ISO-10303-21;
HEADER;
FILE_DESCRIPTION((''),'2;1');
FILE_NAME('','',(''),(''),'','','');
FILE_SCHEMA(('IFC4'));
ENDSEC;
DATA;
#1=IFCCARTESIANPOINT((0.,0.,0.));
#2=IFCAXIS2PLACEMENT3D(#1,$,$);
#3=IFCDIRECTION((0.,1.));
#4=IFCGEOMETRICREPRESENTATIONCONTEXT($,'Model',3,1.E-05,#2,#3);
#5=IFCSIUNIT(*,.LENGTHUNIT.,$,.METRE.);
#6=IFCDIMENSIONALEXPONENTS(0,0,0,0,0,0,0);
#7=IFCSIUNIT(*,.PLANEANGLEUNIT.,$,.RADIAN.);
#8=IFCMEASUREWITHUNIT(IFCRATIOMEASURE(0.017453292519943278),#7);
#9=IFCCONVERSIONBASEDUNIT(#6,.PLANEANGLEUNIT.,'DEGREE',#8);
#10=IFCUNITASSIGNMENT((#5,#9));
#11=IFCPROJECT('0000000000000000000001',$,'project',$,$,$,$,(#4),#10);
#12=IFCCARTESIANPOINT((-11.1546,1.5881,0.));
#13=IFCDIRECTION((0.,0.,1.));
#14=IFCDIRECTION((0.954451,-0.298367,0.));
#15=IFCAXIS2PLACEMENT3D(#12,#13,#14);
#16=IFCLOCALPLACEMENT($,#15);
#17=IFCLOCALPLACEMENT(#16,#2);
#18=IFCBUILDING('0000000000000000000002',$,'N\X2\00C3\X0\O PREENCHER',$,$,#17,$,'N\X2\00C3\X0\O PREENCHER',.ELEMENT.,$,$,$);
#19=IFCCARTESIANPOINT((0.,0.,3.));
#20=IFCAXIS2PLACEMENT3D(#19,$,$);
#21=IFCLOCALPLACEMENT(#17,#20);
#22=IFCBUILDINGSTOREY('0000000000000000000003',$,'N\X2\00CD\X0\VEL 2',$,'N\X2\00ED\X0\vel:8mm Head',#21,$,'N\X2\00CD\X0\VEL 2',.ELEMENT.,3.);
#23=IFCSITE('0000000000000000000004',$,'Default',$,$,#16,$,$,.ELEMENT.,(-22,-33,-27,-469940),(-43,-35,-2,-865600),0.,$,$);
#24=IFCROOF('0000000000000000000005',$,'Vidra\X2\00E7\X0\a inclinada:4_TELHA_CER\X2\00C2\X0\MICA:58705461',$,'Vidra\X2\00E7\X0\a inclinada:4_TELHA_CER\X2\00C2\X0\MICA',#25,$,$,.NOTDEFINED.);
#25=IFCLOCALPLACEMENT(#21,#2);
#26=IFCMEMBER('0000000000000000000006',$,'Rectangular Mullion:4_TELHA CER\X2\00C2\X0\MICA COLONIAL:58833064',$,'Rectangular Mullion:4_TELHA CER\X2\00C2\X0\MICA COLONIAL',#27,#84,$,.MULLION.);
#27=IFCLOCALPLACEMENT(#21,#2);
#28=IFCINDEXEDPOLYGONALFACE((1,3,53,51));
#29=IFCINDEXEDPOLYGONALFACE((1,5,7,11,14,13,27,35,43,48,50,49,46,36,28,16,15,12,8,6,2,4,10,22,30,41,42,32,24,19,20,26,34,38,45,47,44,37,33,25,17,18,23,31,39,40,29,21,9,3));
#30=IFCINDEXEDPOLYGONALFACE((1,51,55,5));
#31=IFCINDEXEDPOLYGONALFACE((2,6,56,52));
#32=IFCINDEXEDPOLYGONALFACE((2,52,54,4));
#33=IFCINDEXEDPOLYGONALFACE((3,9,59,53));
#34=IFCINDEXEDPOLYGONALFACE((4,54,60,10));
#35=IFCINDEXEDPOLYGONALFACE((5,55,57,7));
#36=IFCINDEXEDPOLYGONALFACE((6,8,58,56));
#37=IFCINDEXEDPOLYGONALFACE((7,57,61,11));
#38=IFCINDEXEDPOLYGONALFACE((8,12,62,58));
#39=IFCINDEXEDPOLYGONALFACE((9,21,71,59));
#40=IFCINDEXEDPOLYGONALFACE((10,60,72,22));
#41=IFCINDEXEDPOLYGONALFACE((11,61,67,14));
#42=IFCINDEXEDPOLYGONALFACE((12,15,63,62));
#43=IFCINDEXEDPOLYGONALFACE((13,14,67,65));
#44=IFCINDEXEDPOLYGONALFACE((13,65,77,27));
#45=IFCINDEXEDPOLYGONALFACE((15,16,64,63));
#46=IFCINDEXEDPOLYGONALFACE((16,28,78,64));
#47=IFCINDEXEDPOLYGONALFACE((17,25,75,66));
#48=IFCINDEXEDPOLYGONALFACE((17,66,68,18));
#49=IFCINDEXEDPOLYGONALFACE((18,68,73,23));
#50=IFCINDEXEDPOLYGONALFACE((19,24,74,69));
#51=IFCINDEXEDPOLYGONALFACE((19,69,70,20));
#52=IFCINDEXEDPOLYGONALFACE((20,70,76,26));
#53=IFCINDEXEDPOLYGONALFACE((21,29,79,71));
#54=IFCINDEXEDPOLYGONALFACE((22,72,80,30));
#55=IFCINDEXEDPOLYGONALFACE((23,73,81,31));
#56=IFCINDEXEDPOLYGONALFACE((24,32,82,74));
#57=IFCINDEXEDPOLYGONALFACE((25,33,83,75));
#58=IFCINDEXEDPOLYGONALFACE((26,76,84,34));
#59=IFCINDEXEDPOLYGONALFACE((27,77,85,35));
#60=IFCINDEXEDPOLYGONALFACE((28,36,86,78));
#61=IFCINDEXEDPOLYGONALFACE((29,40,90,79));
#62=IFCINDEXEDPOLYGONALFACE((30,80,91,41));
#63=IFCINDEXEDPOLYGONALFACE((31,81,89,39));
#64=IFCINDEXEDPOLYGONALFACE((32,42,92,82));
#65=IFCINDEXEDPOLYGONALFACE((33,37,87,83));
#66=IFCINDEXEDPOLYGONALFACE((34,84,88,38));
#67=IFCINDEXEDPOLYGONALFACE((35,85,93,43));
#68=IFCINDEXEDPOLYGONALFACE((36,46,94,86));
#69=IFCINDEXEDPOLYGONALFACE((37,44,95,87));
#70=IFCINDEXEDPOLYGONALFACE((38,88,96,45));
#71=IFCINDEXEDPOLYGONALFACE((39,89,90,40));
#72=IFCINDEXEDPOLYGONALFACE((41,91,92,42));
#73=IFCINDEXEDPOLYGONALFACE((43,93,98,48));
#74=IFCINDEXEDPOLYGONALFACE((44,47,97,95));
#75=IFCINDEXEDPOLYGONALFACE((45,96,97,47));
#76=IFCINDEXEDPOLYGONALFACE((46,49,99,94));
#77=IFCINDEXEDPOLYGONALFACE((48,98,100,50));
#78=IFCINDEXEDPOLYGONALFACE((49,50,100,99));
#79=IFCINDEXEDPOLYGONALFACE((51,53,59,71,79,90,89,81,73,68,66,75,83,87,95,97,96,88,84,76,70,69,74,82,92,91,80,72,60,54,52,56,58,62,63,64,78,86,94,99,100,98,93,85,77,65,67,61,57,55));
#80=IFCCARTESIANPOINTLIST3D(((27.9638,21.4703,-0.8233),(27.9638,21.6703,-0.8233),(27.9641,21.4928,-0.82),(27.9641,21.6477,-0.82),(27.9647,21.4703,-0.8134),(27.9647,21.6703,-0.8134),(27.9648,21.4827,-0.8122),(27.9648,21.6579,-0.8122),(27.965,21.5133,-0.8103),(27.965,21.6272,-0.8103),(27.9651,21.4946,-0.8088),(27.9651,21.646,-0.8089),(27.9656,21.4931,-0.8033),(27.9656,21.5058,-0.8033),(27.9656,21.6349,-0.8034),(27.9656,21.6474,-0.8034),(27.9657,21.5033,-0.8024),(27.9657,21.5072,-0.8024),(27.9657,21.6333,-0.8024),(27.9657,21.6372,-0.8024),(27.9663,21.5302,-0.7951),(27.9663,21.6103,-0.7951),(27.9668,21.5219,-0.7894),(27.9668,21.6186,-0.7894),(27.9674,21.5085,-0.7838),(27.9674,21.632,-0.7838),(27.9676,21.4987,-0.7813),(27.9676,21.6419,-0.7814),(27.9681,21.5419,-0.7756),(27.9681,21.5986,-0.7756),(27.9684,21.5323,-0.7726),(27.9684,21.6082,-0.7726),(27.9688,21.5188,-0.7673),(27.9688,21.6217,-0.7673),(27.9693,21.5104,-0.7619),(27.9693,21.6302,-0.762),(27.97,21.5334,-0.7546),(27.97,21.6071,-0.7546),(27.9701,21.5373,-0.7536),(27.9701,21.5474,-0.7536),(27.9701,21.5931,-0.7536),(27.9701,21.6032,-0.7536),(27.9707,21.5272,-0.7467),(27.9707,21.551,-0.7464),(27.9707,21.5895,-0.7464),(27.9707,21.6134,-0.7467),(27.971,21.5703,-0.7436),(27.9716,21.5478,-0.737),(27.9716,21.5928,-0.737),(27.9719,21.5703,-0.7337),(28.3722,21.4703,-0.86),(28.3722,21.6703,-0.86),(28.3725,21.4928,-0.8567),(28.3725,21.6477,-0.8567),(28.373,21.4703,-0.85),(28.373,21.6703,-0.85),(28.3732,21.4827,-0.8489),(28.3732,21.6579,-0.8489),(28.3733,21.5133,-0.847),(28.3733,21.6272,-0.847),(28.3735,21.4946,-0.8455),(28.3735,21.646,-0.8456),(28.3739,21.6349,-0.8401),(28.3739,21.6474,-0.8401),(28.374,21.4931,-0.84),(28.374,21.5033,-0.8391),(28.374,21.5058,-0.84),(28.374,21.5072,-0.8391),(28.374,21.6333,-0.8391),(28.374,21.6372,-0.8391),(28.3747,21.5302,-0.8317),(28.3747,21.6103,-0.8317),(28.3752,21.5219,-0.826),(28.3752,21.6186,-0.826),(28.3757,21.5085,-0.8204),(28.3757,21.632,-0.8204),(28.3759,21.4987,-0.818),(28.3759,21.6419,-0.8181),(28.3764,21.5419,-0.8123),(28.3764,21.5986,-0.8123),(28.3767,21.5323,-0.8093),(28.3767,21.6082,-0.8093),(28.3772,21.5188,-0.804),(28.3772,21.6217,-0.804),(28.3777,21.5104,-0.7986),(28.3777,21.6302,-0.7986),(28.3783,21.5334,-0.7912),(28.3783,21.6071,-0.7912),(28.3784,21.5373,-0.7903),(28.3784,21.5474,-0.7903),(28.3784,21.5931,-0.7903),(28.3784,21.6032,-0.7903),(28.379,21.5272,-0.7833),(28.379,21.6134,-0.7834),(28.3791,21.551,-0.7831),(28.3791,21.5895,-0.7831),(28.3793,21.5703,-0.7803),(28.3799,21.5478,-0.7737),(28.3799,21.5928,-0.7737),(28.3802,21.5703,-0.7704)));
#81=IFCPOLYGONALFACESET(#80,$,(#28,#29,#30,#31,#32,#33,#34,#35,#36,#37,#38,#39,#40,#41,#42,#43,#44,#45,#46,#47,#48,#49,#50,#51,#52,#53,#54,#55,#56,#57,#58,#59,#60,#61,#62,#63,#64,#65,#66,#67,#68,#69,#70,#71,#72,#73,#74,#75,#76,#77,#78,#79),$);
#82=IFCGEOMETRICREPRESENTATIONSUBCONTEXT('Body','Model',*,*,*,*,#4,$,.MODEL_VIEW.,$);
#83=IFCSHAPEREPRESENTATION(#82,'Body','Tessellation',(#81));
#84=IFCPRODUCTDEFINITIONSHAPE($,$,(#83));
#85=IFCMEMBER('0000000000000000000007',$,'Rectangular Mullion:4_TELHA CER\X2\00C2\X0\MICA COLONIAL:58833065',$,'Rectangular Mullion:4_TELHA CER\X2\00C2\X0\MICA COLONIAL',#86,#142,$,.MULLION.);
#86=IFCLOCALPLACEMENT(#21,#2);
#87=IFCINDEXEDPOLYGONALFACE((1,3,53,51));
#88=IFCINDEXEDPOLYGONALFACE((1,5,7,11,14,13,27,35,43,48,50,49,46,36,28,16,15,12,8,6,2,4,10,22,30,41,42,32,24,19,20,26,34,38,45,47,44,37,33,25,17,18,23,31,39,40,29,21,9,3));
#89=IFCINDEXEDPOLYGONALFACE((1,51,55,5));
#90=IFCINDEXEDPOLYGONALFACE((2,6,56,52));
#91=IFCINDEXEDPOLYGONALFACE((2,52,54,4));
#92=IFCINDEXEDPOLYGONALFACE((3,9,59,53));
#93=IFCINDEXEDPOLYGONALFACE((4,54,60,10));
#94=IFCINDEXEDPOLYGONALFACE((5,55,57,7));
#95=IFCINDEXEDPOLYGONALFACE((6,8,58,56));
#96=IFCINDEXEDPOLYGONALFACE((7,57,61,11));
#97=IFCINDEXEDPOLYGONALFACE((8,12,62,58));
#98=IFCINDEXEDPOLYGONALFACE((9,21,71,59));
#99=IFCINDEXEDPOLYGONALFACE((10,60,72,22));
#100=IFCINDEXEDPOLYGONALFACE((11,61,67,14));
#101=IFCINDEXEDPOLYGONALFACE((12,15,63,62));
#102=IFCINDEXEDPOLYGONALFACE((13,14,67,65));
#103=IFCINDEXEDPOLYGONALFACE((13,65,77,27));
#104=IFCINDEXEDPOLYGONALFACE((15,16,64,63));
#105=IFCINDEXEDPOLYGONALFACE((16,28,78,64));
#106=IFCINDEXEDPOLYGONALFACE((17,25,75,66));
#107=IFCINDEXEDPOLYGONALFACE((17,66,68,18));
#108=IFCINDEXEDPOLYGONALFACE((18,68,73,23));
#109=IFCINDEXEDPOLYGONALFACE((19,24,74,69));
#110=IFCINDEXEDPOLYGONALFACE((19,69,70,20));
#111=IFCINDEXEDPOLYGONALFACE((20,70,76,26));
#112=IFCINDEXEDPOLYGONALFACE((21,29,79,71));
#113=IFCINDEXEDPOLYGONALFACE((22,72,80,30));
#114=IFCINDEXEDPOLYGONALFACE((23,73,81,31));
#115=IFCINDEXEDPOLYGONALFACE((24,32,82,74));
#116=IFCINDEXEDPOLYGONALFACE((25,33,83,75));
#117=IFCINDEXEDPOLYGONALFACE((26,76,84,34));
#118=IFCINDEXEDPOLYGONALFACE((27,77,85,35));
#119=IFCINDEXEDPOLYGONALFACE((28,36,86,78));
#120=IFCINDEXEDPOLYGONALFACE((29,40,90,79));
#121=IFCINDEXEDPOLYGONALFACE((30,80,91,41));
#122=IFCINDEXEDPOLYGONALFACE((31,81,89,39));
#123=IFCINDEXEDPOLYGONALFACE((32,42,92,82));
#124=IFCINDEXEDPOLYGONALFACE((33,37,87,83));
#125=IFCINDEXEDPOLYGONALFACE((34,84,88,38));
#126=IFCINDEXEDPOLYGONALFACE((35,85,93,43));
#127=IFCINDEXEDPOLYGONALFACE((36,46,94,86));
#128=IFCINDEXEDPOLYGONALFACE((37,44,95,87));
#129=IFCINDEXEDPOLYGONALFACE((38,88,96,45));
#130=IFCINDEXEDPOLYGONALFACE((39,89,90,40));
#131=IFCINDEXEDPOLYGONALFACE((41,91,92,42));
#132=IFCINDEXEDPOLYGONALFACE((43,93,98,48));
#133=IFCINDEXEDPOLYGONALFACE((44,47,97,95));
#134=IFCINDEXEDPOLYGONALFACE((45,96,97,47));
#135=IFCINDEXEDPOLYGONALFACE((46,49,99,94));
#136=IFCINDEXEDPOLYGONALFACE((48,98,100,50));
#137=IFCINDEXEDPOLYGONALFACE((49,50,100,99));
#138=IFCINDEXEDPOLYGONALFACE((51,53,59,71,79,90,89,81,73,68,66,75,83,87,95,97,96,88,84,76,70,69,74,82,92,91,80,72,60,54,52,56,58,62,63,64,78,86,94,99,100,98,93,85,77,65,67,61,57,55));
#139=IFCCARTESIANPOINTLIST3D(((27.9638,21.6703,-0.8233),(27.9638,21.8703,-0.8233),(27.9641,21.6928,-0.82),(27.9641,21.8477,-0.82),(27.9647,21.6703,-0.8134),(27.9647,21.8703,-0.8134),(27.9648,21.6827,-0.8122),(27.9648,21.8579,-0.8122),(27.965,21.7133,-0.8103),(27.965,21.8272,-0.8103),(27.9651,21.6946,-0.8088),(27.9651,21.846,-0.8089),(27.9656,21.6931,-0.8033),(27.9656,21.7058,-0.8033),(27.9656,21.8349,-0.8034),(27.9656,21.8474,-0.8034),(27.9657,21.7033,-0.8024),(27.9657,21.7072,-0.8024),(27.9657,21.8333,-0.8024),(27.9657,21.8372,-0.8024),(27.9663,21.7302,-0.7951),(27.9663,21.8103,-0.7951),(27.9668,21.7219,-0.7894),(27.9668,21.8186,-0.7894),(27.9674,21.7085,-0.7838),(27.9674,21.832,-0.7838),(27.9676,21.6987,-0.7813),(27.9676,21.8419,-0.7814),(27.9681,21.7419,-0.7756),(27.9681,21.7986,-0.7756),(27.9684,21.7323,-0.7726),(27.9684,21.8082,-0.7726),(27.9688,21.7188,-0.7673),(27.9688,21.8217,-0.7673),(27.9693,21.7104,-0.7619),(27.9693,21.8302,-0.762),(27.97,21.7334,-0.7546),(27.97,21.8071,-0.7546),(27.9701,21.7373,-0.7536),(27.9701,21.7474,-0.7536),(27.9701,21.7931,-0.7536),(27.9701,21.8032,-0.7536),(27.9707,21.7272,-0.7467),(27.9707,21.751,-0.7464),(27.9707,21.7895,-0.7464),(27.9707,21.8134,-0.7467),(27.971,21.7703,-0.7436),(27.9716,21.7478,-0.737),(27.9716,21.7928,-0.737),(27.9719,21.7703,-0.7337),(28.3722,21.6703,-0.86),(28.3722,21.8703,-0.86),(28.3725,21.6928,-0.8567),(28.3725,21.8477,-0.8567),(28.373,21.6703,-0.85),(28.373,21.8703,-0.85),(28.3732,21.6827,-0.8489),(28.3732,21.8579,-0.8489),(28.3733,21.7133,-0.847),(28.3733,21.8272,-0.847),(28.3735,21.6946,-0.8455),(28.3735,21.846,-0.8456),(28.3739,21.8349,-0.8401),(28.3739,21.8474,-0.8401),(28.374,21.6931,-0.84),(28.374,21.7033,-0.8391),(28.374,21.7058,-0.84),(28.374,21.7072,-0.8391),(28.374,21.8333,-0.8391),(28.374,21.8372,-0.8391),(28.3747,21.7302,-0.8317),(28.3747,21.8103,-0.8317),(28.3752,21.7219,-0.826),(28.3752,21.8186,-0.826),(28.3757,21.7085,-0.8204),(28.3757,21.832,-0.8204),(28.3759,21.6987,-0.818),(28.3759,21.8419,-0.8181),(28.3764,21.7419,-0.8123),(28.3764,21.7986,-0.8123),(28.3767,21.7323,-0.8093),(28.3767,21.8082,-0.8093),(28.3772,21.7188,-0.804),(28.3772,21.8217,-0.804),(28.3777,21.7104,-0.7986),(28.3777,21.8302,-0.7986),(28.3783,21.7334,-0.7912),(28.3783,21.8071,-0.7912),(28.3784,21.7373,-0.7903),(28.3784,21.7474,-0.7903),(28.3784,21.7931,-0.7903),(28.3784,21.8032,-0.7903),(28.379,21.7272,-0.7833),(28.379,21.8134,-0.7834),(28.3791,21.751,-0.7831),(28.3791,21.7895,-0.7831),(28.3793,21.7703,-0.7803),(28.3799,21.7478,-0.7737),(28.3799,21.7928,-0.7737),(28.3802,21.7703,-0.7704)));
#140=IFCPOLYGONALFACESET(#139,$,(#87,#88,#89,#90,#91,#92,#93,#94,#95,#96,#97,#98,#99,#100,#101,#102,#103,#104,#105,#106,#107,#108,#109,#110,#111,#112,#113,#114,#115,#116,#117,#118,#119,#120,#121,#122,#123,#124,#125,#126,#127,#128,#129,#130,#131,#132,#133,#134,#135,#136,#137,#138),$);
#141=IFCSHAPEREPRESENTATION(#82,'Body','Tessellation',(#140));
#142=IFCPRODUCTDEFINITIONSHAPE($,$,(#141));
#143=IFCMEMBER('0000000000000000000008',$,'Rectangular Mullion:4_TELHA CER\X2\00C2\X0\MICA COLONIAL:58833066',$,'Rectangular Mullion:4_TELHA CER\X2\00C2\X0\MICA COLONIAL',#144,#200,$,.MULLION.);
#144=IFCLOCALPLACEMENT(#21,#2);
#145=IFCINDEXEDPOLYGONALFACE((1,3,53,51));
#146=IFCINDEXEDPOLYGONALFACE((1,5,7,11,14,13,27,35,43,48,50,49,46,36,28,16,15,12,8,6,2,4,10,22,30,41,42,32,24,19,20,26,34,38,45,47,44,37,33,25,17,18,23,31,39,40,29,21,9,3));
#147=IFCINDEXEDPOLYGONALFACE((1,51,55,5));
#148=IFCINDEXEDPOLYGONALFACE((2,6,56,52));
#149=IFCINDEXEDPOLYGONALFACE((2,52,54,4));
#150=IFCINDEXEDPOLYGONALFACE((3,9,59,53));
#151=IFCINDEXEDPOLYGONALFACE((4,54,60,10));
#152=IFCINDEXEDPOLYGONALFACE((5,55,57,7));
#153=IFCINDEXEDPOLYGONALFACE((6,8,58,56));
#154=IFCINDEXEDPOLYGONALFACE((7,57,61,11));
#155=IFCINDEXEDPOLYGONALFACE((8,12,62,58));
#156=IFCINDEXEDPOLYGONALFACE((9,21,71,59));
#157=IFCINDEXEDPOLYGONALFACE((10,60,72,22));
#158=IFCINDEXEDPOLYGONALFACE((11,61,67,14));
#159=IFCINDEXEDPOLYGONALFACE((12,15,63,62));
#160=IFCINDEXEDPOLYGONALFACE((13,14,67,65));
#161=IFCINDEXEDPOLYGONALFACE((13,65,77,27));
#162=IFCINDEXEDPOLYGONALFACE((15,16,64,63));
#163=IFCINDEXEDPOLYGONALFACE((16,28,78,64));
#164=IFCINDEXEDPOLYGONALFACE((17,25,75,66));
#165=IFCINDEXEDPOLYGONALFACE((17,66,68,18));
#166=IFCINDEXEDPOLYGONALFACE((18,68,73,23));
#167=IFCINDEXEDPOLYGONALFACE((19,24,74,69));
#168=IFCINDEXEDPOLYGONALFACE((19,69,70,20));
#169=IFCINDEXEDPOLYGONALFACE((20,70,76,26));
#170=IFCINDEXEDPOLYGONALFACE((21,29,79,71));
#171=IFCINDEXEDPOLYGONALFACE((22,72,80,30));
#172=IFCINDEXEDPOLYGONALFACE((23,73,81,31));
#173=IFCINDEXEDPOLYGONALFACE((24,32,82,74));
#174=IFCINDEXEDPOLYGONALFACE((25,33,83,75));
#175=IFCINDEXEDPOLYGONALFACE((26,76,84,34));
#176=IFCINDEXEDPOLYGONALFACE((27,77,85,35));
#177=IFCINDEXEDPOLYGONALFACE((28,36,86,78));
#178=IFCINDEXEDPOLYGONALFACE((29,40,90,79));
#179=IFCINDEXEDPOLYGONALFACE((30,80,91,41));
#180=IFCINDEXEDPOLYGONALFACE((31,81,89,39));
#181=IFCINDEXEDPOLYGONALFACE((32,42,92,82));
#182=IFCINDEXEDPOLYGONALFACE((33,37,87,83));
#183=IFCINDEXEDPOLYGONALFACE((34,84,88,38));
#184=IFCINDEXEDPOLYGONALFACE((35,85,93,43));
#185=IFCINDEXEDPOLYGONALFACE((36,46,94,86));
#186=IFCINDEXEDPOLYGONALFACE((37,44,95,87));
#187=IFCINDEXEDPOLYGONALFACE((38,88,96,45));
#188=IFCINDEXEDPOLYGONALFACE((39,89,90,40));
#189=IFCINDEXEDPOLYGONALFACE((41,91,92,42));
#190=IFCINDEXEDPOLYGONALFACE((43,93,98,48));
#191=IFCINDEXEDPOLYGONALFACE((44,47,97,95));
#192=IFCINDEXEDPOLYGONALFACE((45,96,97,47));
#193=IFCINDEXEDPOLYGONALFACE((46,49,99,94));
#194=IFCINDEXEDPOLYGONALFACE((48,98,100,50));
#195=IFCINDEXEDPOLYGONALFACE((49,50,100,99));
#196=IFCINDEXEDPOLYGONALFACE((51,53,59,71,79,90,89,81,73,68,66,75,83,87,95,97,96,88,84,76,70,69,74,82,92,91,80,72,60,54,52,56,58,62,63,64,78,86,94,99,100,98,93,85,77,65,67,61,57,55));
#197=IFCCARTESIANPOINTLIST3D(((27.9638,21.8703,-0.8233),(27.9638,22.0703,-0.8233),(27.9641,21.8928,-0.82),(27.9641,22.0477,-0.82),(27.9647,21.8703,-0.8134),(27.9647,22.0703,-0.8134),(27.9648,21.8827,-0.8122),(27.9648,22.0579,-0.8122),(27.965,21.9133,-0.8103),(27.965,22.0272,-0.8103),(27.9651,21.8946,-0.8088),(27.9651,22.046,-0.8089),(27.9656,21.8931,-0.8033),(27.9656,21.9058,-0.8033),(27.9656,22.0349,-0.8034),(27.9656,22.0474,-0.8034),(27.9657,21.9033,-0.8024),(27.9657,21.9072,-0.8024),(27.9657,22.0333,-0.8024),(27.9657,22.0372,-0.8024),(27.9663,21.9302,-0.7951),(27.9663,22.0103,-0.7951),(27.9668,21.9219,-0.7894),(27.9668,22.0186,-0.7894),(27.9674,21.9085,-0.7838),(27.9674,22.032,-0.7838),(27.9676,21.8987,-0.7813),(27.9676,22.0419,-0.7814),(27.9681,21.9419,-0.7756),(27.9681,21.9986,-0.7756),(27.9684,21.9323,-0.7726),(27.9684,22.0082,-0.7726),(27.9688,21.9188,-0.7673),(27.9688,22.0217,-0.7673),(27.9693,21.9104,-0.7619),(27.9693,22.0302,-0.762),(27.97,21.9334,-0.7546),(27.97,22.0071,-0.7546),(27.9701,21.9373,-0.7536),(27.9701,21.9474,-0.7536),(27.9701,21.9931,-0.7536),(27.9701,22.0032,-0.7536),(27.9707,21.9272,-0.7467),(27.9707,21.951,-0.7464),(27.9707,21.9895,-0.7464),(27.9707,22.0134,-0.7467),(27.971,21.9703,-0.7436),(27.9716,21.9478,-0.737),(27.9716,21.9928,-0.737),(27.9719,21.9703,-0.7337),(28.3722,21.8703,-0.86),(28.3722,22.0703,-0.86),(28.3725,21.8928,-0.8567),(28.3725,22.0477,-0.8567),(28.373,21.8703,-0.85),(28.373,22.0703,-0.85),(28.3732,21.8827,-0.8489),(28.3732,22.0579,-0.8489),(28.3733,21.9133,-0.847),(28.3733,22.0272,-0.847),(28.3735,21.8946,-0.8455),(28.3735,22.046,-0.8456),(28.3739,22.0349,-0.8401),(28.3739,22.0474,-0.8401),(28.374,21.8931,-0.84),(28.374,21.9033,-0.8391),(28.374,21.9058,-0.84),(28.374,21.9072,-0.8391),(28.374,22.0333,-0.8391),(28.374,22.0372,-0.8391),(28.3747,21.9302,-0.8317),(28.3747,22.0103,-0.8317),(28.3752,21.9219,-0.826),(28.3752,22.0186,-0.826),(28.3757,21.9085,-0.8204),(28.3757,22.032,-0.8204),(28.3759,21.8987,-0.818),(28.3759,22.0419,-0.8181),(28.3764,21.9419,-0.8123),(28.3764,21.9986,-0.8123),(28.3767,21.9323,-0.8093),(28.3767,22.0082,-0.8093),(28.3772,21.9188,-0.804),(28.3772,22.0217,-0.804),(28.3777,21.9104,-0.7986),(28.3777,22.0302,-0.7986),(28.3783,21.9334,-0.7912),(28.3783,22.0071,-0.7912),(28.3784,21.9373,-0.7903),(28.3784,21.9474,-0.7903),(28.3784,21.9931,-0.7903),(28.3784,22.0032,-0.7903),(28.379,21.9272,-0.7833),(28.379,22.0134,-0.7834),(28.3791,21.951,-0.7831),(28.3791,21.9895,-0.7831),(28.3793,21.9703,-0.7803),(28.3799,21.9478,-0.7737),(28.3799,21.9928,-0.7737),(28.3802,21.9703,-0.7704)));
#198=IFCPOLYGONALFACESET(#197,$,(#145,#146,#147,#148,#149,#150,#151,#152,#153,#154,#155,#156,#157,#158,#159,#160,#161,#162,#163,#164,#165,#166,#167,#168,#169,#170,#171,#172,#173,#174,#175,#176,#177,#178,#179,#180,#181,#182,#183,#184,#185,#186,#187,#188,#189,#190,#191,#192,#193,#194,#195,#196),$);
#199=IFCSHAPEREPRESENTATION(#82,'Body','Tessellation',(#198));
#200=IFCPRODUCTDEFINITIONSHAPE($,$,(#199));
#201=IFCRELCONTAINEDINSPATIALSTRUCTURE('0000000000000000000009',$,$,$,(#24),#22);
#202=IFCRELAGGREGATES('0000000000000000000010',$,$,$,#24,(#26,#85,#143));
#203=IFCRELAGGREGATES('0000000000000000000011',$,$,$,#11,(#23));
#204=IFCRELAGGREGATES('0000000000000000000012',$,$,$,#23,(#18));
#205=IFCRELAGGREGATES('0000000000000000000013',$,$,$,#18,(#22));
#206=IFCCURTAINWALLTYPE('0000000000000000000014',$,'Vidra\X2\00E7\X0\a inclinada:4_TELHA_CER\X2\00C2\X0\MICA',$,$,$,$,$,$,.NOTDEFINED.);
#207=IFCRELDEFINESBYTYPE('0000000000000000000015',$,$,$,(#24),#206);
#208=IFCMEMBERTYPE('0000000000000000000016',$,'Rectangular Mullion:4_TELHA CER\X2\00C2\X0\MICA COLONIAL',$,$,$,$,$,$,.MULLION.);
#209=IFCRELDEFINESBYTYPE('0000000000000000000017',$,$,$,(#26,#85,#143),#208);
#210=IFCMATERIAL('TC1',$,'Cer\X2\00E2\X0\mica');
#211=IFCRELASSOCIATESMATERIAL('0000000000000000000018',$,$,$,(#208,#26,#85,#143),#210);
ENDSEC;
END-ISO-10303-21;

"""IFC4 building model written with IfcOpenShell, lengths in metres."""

from ifc_helpers import new_model, entity, si_unit, converted_unit, direction, frame, origin, place, context, subcontext, project, spatial, line, arc, indexed_curve, outline, extrude, source, transform, mapped, material, type_object, type_shapes, element, aggregate, save


model = new_model("IFC4")

# Units and contexts
model_context = context("Model", 3, precision=1e-05, world=origin(), true_north=direction((0.0, 1.0)))
body_context = subcontext(model_context, "Body", "Model", "MODEL_VIEW")
ifc_project = project(units=[si_unit("LENGTHUNIT", "METRE"), converted_unit("PLANEANGLEUNIT", "DEGREE", entity("IfcRatioMeasure", 0.017453292519943278), si_unit("PLANEANGLEUNIT", "RADIAN"), dimensions=[0, 0, 0, 0, 0, 0, 0])], contexts=[model_context])

# Site, building, storey
site_placement = place(None, frame((-11.1546, 1.5881, 0.0), z_axis=(0.0, 0.0, 1.0), x_axis=(0.954451, -0.298367, 0.0)))
site = spatial("IfcSite", under=ifc_project, at=site_placement, Name="Default", CompositionType="ELEMENT", RefLatitude=(-22, -33, -27, -469940), RefLongitude=(-43, -35, -2, -865600), RefElevation=0.0)
building_placement = place(site_placement, origin())
building = spatial("IfcBuilding", under=site, at=building_placement, Name="NÃO PREENCHER", LongName="NÃO PREENCHER", CompositionType="ELEMENT")
storey_placement = place(building_placement, frame((0.0, 0.0, 3.0)))
storey = spatial("IfcBuildingStorey", under=building, at=storey_placement, Name="NÍVEL 2", ObjectType="Nível:8mm Head", LongName="NÍVEL 2", CompositionType="ELEMENT", Elevation=3.0)

# Roof, members
curtain_wall_type = type_object("IfcCurtainWallType", Name="Vidraça inclinada:4_TELHA_CERÂMICA", PredefinedType="NOTDEFINED")
roof_placement = place(storey_placement, frame((0.0, 0.0, -3.0)))
roof = element("IfcRoof", 1, at=roof_placement, inside=storey, type_object=curtain_wall_type, Name="Vidraça inclinada:4_TELHA_CERÂMICA:58705461", ObjectType="Vidraça inclinada:4_TELHA_CERÂMICA", PredefinedType="NOTDEFINED")
ifc_material = material(Name="TC1", Category="Cerâmica")
member_type_1 = type_object("IfcMemberType", Name="Rectangular Mullion:4_TELHA CERÂMICA COLONIAL", PredefinedType="MULLION", material=ifc_material)
shared_shape_1 = source(origin(), body_context, "Body", "SweptSolid", [
    extrude(outline(indexed_curve([(-0.029, -0.1), (-0.019, -0.1), (-0.0164, -0.0815), (-0.0089, -0.0645), (-0.0089, -0.0771), (0.061, 0.0), (-0.009, 0.0771), (-0.009, 0.0646), (-0.0165, 0.0816), (-0.019, 0.1), (-0.029, 0.1), (-0.0089, 0.0479), (0.041, 0.0229), (0.041, 0.0329), (0.0131, 0.0425), (-0.008, 0.0631), (-0.008, 0.067), (0.051, 0.0), (-0.008, -0.067), (-0.008, -0.0631), (0.0131, -0.0425), (0.041, -0.0329), (0.041, -0.0229), (-0.0089, -0.0479)], segments=[line(1, 2), arc(2, 3, 4), line(4, 5), arc(5, 6, 7), line(7, 8), arc(8, 9, 10), line(10, 11), arc(11, 12, 13), line(13, 14), arc(14, 15, 16), line(16, 17), arc(17, 18, 19), line(19, 20), arc(20, 21, 22), line(22, 23), arc(23, 24, 1)], self_intersect=False)), frame((0.0, -0.029, -0.41), z_axis=(0.0, 0.0, 1.0), x_axis=(0.0, -1.0, 0.0)), (0.0, 0.0, 1.0), 0.41),
])
type_shapes(member_type_1, [shared_shape_1])
member_1_placement = place(roof_placement, frame((27.9638, 21.5703, 2.1767), z_axis=(-0.99599, 0.0, 0.089469), x_axis=(0.0, 1.0, 0.0)))
member_1 = element("IfcMember", 2, at=member_1_placement, type_object=member_type_1, material=ifc_material, Name="Rectangular Mullion:4_TELHA CERÂMICA COLONIAL:58833064", ObjectType="Rectangular Mullion:4_TELHA CERÂMICA COLONIAL", PredefinedType="MULLION", context=body_context, shape_type="MappedRepresentation", body=[
    mapped(shared_shape_1, transform((0.0, 0.0, 0.0), scale=1.0)),
])
member_2_placement = place(roof_placement, frame((27.9638, 21.7703, 2.1767), z_axis=(-0.99599, 0.0, 0.089469), x_axis=(0.0, 1.0, 0.0)))
member_2 = element("IfcMember", 3, at=member_2_placement, type_object=member_type_1, material=ifc_material, Name="Rectangular Mullion:4_TELHA CERÂMICA COLONIAL:58833065", ObjectType="Rectangular Mullion:4_TELHA CERÂMICA COLONIAL", PredefinedType="MULLION", context=body_context, shape_type="MappedRepresentation", body=[
    mapped(shared_shape_1, transform((0.0, 0.0, 0.0), scale=1.0)),
])
member_3_placement = place(roof_placement, frame((27.9638, 21.9703, 2.1767), z_axis=(-0.99599, 0.0, 0.089469), x_axis=(0.0, 1.0, 0.0)))
member_3 = element("IfcMember", 4, at=member_3_placement, type_object=member_type_1, material=ifc_material, Name="Rectangular Mullion:4_TELHA CERÂMICA COLONIAL:58833066", ObjectType="Rectangular Mullion:4_TELHA CERÂMICA COLONIAL", PredefinedType="MULLION", context=body_context, shape_type="MappedRepresentation", body=[
    mapped(shared_shape_1, transform((0.0, 0.0, 0.0), scale=1.0)),
])
aggregate(roof, [member_1, member_2, member_3])

save(model, "model.ifc")
